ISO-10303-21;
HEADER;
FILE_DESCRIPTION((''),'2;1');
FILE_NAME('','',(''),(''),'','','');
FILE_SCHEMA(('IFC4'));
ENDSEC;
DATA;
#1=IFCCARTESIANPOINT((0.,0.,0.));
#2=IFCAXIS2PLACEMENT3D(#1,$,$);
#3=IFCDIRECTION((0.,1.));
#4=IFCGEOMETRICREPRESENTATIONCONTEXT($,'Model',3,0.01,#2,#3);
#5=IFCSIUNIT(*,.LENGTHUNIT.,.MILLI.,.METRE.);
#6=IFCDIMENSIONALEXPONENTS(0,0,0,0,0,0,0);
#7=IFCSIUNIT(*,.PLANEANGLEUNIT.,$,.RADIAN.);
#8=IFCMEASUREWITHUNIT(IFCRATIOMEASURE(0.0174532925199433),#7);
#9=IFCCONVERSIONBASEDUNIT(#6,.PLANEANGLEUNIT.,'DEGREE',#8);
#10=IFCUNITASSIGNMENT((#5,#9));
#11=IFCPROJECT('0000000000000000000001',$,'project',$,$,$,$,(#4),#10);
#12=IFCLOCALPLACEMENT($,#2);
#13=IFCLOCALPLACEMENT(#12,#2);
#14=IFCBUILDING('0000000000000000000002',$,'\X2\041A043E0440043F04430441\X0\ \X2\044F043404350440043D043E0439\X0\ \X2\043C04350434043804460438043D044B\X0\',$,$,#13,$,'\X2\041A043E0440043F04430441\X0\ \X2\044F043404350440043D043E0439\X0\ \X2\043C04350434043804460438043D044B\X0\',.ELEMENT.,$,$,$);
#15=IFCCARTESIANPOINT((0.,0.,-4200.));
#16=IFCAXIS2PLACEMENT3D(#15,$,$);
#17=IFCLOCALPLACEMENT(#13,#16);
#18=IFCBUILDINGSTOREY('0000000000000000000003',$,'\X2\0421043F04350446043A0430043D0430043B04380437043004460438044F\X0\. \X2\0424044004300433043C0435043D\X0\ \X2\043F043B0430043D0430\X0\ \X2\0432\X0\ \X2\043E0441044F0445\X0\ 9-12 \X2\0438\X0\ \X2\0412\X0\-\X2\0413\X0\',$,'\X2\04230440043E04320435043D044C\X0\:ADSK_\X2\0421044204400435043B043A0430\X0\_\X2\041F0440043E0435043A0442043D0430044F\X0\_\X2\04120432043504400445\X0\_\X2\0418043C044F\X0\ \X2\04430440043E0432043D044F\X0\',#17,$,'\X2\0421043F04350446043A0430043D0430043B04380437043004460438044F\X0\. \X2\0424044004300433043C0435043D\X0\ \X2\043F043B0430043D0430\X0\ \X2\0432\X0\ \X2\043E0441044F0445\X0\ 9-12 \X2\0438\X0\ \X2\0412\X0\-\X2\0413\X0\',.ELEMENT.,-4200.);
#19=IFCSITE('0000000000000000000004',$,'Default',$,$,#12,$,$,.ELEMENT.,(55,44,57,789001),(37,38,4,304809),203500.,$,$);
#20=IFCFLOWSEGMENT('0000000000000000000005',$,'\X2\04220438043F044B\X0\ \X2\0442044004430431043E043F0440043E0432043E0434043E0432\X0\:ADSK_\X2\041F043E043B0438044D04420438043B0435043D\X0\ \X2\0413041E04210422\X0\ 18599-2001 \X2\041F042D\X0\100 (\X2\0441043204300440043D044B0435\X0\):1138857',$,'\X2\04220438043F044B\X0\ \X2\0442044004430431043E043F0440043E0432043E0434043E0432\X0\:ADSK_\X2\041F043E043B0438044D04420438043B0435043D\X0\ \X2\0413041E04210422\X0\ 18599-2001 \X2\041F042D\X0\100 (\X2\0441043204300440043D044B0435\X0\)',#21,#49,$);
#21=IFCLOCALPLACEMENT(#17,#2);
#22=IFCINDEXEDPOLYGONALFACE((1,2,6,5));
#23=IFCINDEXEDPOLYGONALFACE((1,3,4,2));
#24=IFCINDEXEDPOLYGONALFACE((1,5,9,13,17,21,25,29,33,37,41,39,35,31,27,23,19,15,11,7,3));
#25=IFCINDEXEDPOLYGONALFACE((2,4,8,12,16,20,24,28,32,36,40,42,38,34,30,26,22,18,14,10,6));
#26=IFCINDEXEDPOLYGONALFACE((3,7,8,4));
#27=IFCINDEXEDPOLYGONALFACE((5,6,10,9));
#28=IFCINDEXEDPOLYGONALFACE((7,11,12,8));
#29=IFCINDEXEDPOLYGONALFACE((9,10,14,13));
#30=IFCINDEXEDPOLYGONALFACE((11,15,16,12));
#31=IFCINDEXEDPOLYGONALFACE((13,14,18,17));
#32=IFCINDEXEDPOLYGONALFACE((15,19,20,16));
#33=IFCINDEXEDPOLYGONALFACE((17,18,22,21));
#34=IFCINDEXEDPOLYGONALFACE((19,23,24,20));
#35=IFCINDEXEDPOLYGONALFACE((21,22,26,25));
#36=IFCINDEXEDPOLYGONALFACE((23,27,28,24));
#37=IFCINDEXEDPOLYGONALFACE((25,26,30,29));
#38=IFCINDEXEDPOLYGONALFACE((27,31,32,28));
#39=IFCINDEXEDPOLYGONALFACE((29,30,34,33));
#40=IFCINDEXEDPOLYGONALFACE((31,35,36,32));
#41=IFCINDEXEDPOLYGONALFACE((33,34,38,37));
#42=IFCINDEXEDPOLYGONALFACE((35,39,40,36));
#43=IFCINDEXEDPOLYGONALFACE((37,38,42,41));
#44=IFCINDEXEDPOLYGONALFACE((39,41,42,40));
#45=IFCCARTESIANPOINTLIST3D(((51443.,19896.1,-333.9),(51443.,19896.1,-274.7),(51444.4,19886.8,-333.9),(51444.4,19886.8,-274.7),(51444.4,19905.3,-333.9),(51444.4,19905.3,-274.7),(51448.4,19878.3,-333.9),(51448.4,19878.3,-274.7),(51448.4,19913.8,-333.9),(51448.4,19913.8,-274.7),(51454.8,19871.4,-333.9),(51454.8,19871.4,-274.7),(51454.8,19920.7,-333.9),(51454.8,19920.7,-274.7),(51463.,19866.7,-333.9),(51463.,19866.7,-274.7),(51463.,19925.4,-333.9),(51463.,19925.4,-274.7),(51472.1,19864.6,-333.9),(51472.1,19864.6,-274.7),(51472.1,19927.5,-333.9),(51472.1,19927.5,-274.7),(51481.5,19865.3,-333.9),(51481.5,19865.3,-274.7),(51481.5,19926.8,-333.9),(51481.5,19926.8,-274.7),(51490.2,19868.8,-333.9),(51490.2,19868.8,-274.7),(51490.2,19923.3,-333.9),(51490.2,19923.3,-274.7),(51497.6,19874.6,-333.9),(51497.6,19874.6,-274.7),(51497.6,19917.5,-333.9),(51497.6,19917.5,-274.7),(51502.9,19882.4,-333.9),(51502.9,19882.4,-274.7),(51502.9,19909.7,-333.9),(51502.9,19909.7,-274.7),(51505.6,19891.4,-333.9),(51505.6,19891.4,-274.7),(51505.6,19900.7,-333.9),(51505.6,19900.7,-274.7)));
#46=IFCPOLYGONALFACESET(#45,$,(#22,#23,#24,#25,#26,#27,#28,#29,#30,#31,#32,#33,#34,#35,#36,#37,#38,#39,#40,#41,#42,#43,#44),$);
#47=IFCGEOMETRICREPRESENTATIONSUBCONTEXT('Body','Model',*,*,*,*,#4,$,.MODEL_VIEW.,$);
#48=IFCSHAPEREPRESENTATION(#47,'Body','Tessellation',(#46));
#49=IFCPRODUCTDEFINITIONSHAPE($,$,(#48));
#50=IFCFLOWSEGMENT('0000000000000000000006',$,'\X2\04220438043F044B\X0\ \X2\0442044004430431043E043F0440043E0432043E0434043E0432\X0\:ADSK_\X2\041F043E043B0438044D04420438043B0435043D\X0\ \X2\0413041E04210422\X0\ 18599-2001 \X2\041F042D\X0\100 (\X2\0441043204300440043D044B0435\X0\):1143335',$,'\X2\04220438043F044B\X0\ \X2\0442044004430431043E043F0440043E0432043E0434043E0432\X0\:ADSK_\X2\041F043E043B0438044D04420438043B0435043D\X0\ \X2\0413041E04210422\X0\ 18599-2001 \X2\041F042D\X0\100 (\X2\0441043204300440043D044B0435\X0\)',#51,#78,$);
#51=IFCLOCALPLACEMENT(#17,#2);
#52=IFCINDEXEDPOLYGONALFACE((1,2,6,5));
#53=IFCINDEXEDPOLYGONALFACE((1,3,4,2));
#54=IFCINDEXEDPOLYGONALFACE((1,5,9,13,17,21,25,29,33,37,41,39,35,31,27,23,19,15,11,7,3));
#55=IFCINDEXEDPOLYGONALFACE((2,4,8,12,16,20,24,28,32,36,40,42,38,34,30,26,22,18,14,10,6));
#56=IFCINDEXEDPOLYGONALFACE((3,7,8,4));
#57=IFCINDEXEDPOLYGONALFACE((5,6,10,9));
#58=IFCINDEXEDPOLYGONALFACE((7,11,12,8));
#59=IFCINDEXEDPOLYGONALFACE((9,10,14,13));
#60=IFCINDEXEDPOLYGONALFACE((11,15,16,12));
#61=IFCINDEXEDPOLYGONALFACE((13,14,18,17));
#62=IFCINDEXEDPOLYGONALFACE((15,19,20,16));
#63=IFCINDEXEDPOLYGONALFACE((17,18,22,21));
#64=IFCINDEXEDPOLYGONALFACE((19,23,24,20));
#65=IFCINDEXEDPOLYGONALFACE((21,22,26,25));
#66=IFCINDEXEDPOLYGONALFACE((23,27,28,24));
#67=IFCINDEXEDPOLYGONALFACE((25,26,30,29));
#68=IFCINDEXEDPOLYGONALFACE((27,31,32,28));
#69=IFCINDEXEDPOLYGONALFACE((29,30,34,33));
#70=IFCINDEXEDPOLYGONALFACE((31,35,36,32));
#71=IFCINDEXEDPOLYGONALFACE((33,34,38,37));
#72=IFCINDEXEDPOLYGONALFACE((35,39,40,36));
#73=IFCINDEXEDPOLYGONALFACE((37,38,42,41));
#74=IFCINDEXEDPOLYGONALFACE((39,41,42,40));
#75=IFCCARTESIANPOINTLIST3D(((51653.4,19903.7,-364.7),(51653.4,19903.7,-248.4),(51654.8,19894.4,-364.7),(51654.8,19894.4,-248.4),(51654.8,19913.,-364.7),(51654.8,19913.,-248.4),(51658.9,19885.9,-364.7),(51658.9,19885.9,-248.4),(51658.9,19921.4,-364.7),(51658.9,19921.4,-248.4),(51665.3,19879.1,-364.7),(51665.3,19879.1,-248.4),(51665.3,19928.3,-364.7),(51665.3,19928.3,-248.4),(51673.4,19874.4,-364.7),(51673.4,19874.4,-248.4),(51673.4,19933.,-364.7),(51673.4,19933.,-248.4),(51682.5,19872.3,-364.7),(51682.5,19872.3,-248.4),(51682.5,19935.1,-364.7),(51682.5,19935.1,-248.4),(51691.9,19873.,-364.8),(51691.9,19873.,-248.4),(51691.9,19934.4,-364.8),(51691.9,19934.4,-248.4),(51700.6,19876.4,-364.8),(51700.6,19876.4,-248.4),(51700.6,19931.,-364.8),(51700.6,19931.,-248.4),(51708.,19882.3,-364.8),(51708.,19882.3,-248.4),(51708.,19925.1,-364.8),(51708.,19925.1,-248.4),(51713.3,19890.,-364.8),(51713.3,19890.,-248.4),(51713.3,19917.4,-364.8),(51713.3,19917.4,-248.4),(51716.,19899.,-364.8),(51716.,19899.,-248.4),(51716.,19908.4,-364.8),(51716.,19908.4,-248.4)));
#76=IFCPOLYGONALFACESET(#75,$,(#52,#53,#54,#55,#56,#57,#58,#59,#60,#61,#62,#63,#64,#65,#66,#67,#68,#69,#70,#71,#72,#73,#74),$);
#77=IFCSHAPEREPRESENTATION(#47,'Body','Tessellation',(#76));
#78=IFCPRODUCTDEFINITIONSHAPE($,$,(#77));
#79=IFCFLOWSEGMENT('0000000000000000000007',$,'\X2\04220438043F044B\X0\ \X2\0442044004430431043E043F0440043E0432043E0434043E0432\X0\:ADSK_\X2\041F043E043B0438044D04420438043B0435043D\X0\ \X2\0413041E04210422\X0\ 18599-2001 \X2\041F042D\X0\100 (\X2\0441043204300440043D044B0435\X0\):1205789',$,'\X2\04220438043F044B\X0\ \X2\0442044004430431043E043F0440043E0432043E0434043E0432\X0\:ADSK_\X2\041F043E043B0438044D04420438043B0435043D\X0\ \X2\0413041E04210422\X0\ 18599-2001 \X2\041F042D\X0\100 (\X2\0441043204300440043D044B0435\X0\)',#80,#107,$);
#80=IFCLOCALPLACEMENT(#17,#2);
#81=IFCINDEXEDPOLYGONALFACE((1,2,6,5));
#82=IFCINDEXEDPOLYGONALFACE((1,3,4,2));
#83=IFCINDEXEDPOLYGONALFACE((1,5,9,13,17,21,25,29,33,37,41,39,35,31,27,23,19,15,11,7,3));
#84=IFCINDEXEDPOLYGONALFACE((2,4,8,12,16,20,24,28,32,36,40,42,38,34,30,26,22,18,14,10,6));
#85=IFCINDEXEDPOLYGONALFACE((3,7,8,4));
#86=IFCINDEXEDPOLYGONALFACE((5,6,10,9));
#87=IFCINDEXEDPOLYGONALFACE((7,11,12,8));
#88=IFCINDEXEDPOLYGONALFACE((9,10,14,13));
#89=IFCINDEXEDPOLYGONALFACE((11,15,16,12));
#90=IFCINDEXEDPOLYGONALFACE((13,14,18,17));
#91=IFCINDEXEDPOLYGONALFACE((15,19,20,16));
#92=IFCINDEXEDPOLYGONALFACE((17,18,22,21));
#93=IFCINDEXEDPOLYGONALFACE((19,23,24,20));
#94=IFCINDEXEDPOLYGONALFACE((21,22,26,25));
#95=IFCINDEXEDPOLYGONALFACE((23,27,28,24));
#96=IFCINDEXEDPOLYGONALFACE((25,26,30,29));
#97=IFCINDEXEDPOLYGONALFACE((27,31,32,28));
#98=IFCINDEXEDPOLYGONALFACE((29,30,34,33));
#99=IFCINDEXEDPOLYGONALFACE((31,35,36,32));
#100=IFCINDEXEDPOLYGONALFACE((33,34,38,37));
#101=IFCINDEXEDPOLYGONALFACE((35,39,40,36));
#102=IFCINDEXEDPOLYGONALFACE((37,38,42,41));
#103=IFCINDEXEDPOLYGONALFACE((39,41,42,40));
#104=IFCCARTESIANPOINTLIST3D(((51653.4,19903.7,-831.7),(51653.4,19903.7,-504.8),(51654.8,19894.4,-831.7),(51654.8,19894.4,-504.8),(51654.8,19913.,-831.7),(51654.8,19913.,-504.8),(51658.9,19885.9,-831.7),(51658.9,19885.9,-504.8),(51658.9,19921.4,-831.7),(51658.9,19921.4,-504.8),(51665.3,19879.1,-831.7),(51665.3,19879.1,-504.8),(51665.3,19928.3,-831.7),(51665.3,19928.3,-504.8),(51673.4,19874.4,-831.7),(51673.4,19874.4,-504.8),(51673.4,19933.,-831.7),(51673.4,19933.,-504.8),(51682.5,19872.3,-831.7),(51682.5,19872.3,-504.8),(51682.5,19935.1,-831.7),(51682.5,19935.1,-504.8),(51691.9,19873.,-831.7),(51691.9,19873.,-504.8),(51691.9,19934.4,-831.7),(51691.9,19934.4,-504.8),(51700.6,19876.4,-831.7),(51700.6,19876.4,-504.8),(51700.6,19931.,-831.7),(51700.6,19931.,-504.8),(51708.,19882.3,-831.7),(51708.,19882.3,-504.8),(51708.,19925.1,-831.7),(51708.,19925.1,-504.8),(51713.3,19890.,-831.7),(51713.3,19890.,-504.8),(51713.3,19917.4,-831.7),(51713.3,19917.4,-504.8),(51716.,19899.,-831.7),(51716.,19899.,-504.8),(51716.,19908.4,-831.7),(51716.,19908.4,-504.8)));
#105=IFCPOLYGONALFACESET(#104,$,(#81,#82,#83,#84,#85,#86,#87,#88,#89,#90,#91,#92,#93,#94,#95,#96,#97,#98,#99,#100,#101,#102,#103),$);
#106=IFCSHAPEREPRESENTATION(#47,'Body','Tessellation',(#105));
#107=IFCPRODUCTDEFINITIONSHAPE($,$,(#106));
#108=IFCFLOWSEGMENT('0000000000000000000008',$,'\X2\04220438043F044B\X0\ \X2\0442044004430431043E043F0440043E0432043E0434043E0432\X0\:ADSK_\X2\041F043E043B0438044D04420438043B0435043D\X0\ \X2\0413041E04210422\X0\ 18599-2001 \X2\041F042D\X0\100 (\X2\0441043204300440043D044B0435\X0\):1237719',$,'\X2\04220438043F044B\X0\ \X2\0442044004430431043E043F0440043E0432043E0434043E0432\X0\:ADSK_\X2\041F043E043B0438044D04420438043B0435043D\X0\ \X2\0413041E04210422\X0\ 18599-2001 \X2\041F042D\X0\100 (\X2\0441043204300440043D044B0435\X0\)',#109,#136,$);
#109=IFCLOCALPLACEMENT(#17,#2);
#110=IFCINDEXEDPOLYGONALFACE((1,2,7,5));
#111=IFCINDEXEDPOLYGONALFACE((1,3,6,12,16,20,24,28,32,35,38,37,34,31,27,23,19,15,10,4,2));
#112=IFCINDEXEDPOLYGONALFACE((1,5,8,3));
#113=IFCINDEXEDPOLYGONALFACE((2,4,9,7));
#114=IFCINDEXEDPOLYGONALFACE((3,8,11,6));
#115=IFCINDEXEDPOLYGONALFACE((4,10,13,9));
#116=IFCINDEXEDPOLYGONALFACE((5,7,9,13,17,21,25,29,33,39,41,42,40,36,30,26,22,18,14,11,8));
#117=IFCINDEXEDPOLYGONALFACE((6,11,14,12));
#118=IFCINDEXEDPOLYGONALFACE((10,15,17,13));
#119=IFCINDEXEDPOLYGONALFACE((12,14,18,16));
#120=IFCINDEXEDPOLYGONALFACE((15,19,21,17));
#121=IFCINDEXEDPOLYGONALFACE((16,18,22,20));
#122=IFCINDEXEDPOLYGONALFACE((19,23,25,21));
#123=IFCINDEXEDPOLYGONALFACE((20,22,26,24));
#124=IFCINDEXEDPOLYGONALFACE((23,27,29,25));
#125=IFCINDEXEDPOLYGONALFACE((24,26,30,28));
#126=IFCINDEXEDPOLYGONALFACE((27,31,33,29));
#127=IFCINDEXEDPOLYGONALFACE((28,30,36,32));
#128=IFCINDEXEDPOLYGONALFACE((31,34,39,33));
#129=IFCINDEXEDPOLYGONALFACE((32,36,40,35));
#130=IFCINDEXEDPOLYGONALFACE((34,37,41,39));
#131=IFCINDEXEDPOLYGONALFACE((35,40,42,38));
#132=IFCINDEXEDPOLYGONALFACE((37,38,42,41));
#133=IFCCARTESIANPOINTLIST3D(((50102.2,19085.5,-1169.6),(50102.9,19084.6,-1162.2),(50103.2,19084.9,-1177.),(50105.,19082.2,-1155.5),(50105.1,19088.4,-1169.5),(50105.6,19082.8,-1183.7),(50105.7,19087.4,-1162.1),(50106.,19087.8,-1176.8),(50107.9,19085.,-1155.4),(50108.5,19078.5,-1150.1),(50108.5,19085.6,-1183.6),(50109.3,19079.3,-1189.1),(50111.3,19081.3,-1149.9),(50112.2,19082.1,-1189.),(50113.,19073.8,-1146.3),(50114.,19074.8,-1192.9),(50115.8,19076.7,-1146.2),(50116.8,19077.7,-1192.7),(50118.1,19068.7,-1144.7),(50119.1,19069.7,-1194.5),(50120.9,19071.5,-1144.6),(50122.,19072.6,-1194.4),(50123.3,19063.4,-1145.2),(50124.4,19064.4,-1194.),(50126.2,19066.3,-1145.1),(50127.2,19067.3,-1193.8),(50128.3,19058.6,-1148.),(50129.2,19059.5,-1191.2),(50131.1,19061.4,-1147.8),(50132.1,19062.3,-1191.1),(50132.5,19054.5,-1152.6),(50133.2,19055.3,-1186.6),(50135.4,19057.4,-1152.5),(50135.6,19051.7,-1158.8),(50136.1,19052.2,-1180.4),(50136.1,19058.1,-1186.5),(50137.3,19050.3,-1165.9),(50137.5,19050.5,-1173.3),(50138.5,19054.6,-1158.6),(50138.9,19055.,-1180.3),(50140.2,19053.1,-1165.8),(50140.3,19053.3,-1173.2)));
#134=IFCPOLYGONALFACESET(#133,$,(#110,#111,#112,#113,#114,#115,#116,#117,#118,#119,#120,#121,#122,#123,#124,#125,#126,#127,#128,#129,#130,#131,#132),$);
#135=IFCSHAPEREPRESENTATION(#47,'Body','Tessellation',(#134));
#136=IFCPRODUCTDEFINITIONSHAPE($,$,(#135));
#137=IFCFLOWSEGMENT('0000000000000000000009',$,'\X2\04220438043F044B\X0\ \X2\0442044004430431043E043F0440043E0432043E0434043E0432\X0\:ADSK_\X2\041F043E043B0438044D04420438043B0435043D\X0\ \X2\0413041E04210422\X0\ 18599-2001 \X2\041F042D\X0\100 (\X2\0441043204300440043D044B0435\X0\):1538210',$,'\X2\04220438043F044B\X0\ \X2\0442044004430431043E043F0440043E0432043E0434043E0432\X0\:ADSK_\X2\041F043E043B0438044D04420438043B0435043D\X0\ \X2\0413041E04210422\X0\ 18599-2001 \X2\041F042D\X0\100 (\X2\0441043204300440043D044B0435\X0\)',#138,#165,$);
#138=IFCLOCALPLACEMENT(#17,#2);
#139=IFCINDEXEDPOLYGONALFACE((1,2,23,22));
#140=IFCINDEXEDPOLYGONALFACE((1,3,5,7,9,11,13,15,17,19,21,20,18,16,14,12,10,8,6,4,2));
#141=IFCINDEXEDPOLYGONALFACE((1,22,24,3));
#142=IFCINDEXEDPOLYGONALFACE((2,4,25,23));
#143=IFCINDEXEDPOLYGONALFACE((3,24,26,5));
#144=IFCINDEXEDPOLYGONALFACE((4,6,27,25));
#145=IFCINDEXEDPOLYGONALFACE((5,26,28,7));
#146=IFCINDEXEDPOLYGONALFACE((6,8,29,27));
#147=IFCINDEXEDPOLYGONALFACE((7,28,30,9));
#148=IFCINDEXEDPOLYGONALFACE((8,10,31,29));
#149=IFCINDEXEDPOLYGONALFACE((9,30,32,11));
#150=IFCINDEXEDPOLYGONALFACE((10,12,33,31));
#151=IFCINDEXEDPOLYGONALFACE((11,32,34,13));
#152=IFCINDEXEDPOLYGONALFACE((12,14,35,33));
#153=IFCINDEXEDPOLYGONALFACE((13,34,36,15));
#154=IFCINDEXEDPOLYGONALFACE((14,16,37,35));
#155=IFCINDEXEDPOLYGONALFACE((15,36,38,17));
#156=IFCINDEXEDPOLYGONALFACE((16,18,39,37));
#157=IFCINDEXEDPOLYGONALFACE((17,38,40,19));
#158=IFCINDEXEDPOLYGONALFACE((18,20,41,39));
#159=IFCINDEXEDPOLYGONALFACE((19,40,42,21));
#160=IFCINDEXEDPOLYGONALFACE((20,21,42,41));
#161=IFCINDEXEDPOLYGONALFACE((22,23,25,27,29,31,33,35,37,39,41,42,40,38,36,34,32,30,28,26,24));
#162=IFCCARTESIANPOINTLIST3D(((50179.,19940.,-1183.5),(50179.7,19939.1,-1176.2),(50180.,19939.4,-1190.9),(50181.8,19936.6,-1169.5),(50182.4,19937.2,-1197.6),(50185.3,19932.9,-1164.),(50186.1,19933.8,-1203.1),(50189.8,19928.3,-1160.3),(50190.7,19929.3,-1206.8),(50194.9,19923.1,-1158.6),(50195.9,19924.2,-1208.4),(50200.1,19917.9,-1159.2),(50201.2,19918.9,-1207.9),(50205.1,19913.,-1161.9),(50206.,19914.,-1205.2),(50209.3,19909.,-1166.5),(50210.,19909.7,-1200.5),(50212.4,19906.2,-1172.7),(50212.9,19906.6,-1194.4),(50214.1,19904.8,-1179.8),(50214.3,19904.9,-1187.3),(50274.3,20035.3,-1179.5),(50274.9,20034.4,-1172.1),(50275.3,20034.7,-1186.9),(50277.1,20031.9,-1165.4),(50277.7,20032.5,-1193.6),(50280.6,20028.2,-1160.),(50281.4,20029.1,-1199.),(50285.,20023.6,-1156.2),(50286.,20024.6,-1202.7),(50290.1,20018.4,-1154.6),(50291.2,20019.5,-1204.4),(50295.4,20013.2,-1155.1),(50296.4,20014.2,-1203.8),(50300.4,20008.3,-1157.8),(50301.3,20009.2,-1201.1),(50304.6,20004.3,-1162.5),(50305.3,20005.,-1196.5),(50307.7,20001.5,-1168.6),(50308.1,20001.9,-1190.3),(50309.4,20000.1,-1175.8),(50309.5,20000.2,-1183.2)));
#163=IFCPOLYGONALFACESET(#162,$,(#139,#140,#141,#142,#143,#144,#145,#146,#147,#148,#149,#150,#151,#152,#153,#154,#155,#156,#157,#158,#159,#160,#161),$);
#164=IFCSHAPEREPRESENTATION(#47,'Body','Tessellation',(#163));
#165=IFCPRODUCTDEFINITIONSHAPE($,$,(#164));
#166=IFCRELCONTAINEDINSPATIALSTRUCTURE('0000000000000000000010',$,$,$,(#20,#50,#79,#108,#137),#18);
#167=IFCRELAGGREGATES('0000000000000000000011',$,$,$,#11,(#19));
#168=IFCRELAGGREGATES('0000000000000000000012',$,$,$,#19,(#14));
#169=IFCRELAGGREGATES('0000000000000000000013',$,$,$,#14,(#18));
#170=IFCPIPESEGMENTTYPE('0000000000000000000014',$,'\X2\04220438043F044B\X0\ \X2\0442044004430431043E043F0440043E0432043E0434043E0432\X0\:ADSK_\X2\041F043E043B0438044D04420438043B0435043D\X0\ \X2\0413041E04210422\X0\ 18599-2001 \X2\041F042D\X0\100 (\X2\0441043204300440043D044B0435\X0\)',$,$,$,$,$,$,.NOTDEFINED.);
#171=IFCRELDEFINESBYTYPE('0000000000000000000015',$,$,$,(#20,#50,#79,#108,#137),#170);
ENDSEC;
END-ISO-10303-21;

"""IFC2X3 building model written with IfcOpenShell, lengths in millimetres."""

from ifc_helpers import new_model, entity, si_unit, converted_unit, direction, frame, origin, origin_2d_with_axis, place, context, subcontext, project, spatial, circle, extrude, type_object, element, save


model = new_model("IFC2X3")

# Units and contexts
model_context = context("Model", 3, precision=0.01, world=origin(), true_north=direction((0.0, 1.0)))
body_context = subcontext(model_context, "Body", "Model", "MODEL_VIEW")
ifc_project = project(units=[si_unit("LENGTHUNIT", "METRE", prefix="MILLI"), converted_unit("PLANEANGLEUNIT", "DEGREE", entity("IfcRatioMeasure", 0.0174532925199433), si_unit("PLANEANGLEUNIT", "RADIAN"), dimensions=[0, 0, 0, 0, 0, 0, 0])], contexts=[model_context])

# Site, building, storey
site_placement = place(None, origin())
site = spatial("IfcSite", under=ifc_project, at=site_placement, Name="Default", CompositionType="ELEMENT", RefLatitude=(55, 44, 57, 789001), RefLongitude=(37, 38, 4, 304809), RefElevation=203500.0)
building_placement = place(site_placement, origin())
building = spatial("IfcBuilding", under=site, at=building_placement, Name="Корпус ядерной медицины", LongName="Корпус ядерной медицины", CompositionType="ELEMENT")
storey_placement = place(building_placement, frame((0.0, 0.0, -4200.0)))
storey = spatial("IfcBuildingStorey", under=building, at=storey_placement, Name="Спецканализация. Фрагмен плана в осях 9-12 и В-Г", ObjectType="Уровень:ADSK_Стрелка_Проектная_Вверх_Имя уровня", LongName="Спецканализация. Фрагмен плана в осях 9-12 и В-Г", CompositionType="ELEMENT", Elevation=-4200.0)

# Flow segments
pipe_segment_type = type_object("IfcPipeSegmentType", Name="Типы трубопроводов:ADSK_Полиэтилен ГОСТ 18599-2001 ПЭ100 (сварные)", PredefinedType="NOTDEFINED")
flow_segment_1_placement = place(storey_placement, frame((51441.4, 19863.0, -333.9)))
element("IfcFlowSegment", 1, at=flow_segment_1_placement, inside=storey, type_object=pipe_segment_type, Name="Типы трубопроводов:ADSK_Полиэтилен ГОСТ 18599-2001 ПЭ100 (сварные):1138857", ObjectType="Типы трубопроводов:ADSK_Полиэтилен ГОСТ 18599-2001 ПЭ100 (сварные)", context=body_context, shape_type="SweptSolid", body=[
    extrude(circle(Radius=31.5, at=origin_2d_with_axis()), frame((33.1, 33.1, 0.0), z_axis=(0.000007, 0.0, 1.0), x_axis=(-1.0, 0.0, 0.000007)), (0.0, 0.0, 1.0), 59.1),
])
flow_segment_2_placement = place(storey_placement, frame((51651.8, 19870.6, -364.8)))
element("IfcFlowSegment", 2, at=flow_segment_2_placement, inside=storey, type_object=pipe_segment_type, Name="Типы трубопроводов:ADSK_Полиэтилен ГОСТ 18599-2001 ПЭ100 (сварные):1143335", ObjectType="Типы трубопроводов:ADSK_Полиэтилен ГОСТ 18599-2001 ПЭ100 (сварные)", context=body_context, shape_type="SweptSolid", body=[
    extrude(circle(Radius=31.5, at=origin_2d_with_axis()), frame((33.1, 33.1, 0.0), z_axis=(0.000001, 0.0, 1.0), x_axis=(-1.0, 0.0, 0.000001)), (0.0, 0.0, 1.0), 116.3),
])
flow_segment_3_placement = place(storey_placement, frame((51651.8, 19870.6, -831.7)))
element("IfcFlowSegment", 3, at=flow_segment_3_placement, inside=storey, type_object=pipe_segment_type, Name="Типы трубопроводов:ADSK_Полиэтилен ГОСТ 18599-2001 ПЭ100 (сварные):1205789", ObjectType="Типы трубопроводов:ADSK_Полиэтилен ГОСТ 18599-2001 ПЭ100 (сварные)", context=body_context, shape_type="SweptSolid", body=[
    extrude(circle(Radius=31.5, at=origin_2d_with_axis()), frame((33.1, 33.1, 0.0), z_axis=(0.000002, 0.0, 1.0), x_axis=(-1.0, 0.0, 0.000002)), (0.0, 0.0, 1.0), 327.0),
])
flow_segment_4_placement = place(storey_placement, frame((50100.7, 19048.6, -1196.2)))
element("IfcFlowSegment", 4, at=flow_segment_4_placement, inside=storey, type_object=pipe_segment_type, Name="Типы трубопроводов:ADSK_Полиэтилен ГОСТ 18599-2001 ПЭ100 (сварные):1237719", ObjectType="Типы трубопроводов:ADSK_Полиэтилен ГОСТ 18599-2001 ПЭ100 (сварные)", context=body_context, shape_type="SweptSolid", body=[
    extrude(circle(Radius=25.0, at=origin_2d_with_axis()), frame((19.3, 19.3, 26.6), z_axis=(0.706789, 0.706789, 0.029987), x_axis=(-0.707107, 0.707107, 0.0)), (0.0, 0.0, 1.0), 4.0),
])
flow_segment_5_placement = place(storey_placement, frame((50177.4, 19903.1, -1210.1)))
element("IfcFlowSegment", 5, at=flow_segment_5_placement, inside=storey, type_object=pipe_segment_type, Name="Типы трубопроводов:ADSK_Полиэтилен ГОСТ 18599-2001 ПЭ100 (сварные):1538210", ObjectType="Типы трубопроводов:ADSK_Полиэтилен ГОСТ 18599-2001 ПЭ100 (сварные)", context=body_context, shape_type="SweptSolid", body=[
    extrude(circle(Radius=25.0, at=origin_2d_with_axis()), frame((19.3, 19.3, 26.6), z_axis=(0.706789, 0.706789, 0.029987), x_axis=(-0.707107, 0.707107, 0.0)), (0.0, 0.0, 1.0), 134.8),
])

save(model, "model.ifc")
